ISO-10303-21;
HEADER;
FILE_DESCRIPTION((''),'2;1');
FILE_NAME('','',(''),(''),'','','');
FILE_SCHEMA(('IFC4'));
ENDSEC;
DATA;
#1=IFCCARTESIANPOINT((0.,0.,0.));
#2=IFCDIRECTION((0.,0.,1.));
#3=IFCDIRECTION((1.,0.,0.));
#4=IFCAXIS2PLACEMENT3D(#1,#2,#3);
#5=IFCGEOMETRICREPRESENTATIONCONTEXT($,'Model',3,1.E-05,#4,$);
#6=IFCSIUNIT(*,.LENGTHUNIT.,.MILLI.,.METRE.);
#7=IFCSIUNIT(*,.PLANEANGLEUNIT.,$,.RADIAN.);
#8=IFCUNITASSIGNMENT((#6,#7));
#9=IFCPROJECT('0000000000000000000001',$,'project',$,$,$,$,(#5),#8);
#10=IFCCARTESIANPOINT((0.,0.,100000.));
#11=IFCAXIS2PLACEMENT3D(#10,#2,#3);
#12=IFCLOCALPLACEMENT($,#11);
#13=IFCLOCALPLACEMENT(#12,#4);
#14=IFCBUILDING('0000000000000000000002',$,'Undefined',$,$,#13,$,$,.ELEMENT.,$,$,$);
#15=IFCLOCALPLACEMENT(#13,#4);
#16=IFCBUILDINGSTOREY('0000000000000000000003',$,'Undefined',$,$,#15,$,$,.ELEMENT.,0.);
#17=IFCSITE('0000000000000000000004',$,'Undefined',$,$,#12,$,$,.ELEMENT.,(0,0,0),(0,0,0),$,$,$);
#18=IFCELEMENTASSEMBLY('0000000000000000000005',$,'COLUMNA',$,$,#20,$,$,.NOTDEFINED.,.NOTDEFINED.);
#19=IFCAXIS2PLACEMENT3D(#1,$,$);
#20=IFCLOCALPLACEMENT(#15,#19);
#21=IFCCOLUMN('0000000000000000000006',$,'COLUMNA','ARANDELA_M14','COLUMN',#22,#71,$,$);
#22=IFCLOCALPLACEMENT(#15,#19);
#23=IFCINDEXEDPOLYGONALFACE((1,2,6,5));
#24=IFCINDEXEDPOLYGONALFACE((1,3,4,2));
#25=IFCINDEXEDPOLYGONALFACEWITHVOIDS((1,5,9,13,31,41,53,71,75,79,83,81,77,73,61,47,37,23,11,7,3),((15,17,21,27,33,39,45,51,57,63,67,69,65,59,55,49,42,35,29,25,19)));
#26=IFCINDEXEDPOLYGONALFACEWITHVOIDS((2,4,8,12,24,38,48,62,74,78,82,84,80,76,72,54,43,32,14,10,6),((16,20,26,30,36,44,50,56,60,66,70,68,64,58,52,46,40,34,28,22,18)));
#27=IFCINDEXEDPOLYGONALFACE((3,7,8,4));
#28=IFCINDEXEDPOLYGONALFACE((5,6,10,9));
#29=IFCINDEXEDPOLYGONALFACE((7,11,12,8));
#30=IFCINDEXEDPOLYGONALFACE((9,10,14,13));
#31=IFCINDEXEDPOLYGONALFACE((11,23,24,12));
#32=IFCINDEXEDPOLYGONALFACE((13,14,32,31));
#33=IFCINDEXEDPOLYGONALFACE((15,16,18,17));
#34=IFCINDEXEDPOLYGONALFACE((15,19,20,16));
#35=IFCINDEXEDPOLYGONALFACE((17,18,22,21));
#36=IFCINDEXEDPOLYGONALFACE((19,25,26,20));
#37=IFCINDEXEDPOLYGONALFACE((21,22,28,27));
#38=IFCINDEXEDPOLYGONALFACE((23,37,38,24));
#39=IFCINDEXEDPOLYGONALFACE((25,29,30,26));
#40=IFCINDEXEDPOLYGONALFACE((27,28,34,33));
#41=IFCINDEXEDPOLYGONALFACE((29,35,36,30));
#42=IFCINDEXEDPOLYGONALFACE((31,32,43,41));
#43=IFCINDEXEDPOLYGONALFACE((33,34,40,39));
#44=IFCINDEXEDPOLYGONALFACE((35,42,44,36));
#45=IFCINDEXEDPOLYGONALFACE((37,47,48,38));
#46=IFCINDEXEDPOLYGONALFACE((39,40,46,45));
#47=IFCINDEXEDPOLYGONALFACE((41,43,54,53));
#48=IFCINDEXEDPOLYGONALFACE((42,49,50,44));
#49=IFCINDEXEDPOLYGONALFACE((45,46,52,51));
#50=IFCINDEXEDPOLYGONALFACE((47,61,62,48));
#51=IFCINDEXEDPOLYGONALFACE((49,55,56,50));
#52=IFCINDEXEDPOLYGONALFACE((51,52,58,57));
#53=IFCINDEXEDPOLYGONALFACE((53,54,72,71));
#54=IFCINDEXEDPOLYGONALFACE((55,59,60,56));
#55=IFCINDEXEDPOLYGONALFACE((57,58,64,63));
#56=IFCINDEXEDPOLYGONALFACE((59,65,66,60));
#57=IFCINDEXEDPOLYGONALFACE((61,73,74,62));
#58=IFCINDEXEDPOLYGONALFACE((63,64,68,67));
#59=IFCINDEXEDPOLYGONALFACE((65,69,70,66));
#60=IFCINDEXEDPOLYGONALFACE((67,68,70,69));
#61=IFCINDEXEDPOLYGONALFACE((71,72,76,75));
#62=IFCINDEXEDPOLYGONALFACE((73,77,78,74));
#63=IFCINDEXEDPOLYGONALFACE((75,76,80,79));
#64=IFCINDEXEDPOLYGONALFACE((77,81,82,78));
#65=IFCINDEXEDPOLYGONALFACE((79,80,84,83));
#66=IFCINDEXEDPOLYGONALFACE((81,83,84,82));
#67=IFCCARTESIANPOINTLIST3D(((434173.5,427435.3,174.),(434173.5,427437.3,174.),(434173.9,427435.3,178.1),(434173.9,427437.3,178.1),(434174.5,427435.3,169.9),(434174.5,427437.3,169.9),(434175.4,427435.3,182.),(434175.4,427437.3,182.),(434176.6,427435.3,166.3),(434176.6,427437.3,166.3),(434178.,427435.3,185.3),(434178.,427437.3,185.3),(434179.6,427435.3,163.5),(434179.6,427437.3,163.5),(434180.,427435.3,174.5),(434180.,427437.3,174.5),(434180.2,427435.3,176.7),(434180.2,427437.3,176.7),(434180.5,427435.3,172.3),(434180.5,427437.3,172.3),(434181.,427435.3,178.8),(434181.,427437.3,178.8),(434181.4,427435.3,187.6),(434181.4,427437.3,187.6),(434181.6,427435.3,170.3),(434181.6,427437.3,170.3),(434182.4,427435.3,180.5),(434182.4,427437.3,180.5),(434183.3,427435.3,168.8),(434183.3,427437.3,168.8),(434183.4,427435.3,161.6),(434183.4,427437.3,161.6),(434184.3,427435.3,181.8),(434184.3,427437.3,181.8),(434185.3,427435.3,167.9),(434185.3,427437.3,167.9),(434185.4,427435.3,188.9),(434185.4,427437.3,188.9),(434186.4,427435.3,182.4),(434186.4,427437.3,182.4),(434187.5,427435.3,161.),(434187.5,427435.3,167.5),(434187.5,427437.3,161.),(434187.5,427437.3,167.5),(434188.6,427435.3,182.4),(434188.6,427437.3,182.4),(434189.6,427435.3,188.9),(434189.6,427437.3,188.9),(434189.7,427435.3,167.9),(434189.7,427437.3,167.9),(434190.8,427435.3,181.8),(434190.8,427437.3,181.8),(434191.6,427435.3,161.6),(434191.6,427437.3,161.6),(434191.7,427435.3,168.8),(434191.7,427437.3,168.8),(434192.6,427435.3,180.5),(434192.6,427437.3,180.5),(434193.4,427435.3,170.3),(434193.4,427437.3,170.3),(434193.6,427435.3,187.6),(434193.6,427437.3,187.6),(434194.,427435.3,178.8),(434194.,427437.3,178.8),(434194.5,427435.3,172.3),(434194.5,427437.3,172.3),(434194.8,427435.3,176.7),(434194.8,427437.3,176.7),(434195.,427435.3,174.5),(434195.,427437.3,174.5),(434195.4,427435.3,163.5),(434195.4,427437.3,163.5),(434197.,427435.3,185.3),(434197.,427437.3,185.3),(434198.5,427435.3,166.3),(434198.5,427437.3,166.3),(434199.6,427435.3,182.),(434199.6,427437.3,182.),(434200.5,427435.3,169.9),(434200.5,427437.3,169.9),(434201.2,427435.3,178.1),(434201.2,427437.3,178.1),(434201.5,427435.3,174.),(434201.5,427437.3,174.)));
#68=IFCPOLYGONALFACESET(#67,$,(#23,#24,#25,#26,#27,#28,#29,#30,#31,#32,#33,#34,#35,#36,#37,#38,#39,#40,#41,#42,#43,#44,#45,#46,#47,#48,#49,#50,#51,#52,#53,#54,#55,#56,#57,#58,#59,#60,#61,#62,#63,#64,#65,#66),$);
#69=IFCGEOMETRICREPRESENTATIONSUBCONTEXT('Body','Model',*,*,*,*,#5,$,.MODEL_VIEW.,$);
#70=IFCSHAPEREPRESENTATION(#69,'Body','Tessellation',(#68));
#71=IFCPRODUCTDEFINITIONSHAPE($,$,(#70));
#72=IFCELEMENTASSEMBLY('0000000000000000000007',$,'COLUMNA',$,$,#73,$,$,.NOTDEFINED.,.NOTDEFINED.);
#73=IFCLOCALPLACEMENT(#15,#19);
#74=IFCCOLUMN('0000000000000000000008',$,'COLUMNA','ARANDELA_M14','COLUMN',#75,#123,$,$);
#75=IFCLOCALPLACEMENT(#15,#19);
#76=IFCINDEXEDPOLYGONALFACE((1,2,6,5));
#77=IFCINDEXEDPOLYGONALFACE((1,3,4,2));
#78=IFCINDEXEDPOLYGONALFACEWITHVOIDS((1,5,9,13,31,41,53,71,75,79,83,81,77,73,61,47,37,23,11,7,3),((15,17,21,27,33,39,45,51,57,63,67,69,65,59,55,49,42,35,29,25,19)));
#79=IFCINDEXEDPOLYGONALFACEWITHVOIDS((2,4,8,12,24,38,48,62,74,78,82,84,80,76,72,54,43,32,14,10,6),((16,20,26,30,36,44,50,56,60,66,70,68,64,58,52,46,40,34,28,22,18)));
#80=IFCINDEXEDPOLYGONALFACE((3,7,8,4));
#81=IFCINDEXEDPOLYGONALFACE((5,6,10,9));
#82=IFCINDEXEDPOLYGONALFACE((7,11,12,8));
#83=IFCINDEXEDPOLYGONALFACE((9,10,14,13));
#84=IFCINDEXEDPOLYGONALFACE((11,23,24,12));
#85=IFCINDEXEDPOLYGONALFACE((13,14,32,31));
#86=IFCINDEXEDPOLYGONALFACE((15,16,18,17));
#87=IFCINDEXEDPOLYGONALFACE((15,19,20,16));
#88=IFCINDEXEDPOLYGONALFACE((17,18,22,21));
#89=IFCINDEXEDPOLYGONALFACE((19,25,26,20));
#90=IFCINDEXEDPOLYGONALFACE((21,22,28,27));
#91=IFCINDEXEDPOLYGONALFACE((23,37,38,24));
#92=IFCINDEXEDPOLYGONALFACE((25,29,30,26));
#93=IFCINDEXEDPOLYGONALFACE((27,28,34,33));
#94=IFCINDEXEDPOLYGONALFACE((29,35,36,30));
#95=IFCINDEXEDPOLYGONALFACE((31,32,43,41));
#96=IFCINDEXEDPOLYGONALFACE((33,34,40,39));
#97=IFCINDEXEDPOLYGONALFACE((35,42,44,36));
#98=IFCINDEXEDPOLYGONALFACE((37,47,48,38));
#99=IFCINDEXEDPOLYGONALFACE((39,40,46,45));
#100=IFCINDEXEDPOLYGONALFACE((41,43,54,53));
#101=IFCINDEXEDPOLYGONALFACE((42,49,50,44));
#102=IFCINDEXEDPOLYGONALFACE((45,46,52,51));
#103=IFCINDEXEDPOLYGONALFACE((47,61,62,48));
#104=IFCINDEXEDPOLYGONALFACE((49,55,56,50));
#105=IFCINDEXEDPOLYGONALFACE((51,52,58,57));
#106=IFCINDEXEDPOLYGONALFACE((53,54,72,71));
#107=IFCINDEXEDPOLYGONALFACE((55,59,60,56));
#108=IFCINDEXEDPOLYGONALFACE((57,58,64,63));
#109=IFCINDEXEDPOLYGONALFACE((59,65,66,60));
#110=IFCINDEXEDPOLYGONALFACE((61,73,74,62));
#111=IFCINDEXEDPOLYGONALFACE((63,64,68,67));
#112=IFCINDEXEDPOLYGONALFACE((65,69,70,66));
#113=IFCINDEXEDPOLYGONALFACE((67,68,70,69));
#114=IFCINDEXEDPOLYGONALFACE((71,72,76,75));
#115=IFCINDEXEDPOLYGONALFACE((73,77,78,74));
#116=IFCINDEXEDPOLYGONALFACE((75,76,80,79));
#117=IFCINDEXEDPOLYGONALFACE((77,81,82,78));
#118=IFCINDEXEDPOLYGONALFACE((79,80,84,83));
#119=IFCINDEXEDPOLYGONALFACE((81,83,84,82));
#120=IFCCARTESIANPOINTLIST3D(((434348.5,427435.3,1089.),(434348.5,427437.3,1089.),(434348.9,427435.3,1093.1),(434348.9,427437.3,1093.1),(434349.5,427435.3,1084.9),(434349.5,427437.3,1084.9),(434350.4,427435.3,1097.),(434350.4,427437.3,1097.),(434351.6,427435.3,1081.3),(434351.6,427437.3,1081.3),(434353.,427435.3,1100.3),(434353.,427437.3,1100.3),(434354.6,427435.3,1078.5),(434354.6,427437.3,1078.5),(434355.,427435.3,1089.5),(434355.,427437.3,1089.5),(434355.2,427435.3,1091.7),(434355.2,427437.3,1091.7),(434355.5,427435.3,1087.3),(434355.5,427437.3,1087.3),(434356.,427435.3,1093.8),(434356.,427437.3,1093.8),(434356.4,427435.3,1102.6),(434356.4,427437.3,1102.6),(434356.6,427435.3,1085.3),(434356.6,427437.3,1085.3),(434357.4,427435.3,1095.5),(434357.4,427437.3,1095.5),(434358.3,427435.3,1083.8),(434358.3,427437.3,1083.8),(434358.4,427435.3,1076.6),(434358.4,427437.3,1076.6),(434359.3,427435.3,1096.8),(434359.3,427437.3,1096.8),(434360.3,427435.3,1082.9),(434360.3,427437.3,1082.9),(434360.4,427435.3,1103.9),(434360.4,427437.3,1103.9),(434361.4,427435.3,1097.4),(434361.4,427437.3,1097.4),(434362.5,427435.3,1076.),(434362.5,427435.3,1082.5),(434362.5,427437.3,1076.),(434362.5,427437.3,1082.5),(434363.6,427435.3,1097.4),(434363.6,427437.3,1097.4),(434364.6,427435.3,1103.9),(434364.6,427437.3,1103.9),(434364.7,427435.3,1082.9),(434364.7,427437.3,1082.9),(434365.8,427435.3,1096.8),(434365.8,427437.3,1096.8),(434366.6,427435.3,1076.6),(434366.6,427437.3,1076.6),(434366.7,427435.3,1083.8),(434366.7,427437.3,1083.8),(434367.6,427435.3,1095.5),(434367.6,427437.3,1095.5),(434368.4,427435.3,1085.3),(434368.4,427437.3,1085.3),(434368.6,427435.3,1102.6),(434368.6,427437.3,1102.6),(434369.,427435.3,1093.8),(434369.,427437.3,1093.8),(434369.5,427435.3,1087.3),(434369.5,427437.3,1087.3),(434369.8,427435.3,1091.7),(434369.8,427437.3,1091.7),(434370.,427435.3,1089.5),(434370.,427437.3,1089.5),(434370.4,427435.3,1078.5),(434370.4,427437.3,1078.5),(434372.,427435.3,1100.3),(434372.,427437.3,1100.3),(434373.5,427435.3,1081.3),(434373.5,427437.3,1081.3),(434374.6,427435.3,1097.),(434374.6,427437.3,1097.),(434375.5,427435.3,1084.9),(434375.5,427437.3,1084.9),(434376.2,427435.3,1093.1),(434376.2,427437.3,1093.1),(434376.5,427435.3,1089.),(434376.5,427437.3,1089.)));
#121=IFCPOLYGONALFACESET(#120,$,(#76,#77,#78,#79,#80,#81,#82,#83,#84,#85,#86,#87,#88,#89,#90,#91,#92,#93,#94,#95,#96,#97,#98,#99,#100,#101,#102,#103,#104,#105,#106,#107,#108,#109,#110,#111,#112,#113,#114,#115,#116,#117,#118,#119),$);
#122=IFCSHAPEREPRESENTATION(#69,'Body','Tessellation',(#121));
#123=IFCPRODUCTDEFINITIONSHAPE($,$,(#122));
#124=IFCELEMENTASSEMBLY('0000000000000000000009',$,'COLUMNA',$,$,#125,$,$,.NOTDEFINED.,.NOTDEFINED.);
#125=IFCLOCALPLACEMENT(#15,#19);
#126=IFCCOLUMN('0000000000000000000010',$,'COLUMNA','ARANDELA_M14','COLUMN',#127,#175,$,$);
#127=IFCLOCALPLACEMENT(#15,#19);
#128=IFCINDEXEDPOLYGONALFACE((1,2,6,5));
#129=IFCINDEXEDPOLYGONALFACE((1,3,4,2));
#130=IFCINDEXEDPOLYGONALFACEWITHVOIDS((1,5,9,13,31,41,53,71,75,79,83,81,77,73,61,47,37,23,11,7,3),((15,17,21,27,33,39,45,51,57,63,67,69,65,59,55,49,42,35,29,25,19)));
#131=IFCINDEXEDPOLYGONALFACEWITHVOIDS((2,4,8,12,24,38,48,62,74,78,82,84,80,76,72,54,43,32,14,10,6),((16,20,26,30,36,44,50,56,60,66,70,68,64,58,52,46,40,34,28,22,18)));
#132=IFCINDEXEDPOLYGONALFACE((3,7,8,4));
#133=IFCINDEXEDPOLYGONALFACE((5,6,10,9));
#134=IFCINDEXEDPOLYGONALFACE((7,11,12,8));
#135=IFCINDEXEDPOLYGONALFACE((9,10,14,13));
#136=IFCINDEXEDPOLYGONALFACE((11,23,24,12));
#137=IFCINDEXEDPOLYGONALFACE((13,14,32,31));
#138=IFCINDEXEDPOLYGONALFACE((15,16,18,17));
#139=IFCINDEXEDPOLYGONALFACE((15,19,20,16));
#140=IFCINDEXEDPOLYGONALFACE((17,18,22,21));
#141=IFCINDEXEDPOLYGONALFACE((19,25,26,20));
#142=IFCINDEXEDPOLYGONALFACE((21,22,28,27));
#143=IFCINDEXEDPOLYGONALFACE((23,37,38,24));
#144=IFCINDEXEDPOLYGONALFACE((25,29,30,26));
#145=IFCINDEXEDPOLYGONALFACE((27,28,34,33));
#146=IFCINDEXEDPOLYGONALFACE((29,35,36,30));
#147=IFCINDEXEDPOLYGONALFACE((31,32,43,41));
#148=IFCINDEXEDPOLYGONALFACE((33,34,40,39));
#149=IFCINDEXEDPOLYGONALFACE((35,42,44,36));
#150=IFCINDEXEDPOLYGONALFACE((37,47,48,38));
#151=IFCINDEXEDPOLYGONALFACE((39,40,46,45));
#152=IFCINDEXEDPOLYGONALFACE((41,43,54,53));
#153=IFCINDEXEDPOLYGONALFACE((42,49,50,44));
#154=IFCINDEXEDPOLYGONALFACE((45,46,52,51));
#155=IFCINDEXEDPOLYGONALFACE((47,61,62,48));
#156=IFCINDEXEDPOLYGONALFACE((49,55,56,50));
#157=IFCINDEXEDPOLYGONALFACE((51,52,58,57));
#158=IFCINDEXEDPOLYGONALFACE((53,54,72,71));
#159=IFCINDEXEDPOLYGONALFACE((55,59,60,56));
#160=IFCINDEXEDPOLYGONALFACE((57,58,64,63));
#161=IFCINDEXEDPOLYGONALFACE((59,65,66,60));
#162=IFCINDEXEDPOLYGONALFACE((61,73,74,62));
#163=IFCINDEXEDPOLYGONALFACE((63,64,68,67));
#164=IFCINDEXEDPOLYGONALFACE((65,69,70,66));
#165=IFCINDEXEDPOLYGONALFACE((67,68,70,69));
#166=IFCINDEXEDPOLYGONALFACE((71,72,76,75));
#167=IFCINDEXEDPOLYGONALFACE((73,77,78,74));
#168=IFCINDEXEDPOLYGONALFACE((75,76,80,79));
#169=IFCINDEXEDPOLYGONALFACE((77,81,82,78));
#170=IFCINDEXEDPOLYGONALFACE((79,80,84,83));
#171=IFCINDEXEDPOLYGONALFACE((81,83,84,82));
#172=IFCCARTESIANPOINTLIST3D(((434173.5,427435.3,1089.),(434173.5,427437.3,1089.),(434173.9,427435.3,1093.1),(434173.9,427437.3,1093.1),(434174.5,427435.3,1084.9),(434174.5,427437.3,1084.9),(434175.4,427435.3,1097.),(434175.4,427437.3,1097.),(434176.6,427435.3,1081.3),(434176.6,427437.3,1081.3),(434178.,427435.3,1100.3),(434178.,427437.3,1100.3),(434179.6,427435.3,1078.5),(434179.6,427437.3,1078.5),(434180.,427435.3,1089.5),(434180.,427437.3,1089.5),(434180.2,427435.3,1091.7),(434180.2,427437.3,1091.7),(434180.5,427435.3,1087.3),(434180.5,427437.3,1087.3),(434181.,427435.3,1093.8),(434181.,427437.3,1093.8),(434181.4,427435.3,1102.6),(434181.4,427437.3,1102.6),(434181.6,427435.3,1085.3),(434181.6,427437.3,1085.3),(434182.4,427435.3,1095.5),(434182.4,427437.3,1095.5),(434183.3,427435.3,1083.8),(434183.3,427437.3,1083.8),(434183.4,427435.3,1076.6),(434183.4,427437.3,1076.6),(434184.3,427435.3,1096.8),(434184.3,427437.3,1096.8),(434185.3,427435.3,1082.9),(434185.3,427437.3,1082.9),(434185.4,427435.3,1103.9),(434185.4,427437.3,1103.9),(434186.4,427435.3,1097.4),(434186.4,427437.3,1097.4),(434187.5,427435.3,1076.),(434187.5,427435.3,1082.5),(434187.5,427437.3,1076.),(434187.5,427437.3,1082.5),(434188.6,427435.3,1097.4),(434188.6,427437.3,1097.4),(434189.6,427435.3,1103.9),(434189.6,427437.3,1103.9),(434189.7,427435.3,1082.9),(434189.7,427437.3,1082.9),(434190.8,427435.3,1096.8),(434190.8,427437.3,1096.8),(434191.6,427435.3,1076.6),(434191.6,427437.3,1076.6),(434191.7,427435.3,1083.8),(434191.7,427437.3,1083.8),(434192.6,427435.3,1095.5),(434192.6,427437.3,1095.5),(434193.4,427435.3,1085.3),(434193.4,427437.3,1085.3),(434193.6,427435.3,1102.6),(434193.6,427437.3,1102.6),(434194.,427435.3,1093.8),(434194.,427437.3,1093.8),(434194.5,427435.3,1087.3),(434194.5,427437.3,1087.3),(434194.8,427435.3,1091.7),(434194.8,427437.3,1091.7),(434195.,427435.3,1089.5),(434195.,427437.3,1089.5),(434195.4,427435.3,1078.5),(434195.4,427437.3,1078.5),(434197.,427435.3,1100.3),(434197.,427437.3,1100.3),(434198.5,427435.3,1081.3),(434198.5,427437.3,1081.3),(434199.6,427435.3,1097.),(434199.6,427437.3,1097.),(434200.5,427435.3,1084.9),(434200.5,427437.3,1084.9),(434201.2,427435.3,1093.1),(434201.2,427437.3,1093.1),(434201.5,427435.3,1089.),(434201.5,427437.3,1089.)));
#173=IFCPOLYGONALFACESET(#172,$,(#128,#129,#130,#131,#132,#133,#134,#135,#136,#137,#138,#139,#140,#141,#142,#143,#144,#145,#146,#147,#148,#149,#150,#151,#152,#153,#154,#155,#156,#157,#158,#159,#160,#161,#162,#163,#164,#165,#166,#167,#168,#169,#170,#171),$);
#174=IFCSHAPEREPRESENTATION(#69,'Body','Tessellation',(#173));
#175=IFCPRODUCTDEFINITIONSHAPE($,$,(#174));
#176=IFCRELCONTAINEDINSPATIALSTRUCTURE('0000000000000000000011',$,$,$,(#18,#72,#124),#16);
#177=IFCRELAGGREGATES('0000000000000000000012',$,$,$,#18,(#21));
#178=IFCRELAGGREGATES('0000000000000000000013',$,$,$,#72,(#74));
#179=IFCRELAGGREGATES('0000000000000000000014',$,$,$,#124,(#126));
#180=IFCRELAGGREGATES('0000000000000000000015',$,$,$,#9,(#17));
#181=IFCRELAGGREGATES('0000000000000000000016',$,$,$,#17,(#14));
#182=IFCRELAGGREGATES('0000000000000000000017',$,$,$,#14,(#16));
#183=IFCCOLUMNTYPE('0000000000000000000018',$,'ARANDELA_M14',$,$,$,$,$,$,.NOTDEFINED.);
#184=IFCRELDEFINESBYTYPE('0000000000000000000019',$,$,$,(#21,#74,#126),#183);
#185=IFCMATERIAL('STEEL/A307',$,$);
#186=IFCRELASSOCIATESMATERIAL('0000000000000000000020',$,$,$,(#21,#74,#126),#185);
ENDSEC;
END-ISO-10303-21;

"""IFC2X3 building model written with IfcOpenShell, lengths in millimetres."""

from ifc_helpers import new_model, si_unit, frame, origin_with_axes, origin_2d_with_axis, place, context, subcontext, project, spatial, hollow_circle, extrude, material, type_object, element, aggregate, save


model = new_model("IFC2X3")

# Units and contexts
model_context = context("Model", 3, precision=1e-05, world=origin_with_axes())
body_context = subcontext(model_context, "Body", "Model", "MODEL_VIEW")
ifc_project = project(units=[si_unit("LENGTHUNIT", "METRE", prefix="MILLI"), si_unit("PLANEANGLEUNIT", "RADIAN")], contexts=[model_context])

# Site, building, storey
site_placement = place(None, frame((0.0, 0.0, 100000.0), z_axis=(0.0, 0.0, 1.0), x_axis=(1.0, 0.0, 0.0)))
site = spatial("IfcSite", under=ifc_project, at=site_placement, Name="Undefined", CompositionType="ELEMENT", RefLatitude=(0, 0, 0), RefLongitude=(0, 0, 0))
building_placement = place(site_placement, origin_with_axes())
building = spatial("IfcBuilding", under=site, at=building_placement, Name="Undefined", CompositionType="ELEMENT")
storey_placement = place(building_placement, origin_with_axes())
storey = spatial("IfcBuildingStorey", under=building, at=storey_placement, Name="Undefined", CompositionType="ELEMENT", Elevation=0.0)

# Element assemblies, columns
ifc_material_1 = material(Name="STEEL/A307")
column_type_1 = type_object("IfcColumnType", Name="ARANDELA_M14", PredefinedType="NOTDEFINED")
assembly_1_placement = place(storey_placement, origin_with_axes())
assembly_1 = element("IfcElementAssembly", 1, at=assembly_1_placement, inside=storey, Name="COLUMNA", AssemblyPlace="NOTDEFINED", PredefinedType="NOTDEFINED")
column_1_placement = place(assembly_1_placement, frame((434187.5, 427437.3, 175.0), z_axis=(0.0, -1.0, 0.000285), x_axis=(-1.0, 0.0, 0.0)))
column_1 = element("IfcColumn", 2, at=column_1_placement, type_object=column_type_1, material=ifc_material_1, Name="COLUMNA", Description="ARANDELA_M14", ObjectType="COLUMN", context=body_context, shape_type="SweptSolid", body=[
    extrude(hollow_circle(Radius=14.0, WallThickness=6.5, at=origin_2d_with_axis()), frame((0.0, 0.0, 2.0), z_axis=(0.0, 0.0, -1.0), x_axis=(0.0, 1.0, 0.0)), (0.0, 0.0, 1.0), 2.0),
])
aggregate(assembly_1, [column_1])
assembly_2_placement = place(storey_placement, origin_with_axes())
assembly_2 = element("IfcElementAssembly", 3, at=assembly_2_placement, inside=storey, Name="COLUMNA", AssemblyPlace="NOTDEFINED", PredefinedType="NOTDEFINED")
column_2_placement = place(assembly_2_placement, frame((434362.5, 427437.3, 1090.0), z_axis=(0.0, -1.0, 0.000285), x_axis=(-1.0, 0.0, 0.0)))
column_2 = element("IfcColumn", 4, at=column_2_placement, type_object=column_type_1, material=ifc_material_1, Name="COLUMNA", Description="ARANDELA_M14", ObjectType="COLUMN", context=body_context, shape_type="SweptSolid", body=[
    extrude(hollow_circle(Radius=14.0, WallThickness=6.5, at=origin_2d_with_axis()), frame((0.0, 0.0, 2.0), z_axis=(0.0, 0.0, -1.0), x_axis=(0.0, 1.0, 0.0)), (0.0, 0.0, 1.0), 2.0),
])
aggregate(assembly_2, [column_2])
assembly_3_placement = place(storey_placement, origin_with_axes())
assembly_3 = element("IfcElementAssembly", 5, at=assembly_3_placement, inside=storey, Name="COLUMNA", AssemblyPlace="NOTDEFINED", PredefinedType="NOTDEFINED")
column_3_placement = place(assembly_3_placement, frame((434187.5, 427437.3, 1090.0), z_axis=(0.0, -1.0, 0.000285), x_axis=(-1.0, 0.0, 0.0)))
column_3 = element("IfcColumn", 6, at=column_3_placement, type_object=column_type_1, material=ifc_material_1, Name="COLUMNA", Description="ARANDELA_M14", ObjectType="COLUMN", context=body_context, shape_type="SweptSolid", body=[
    extrude(hollow_circle(Radius=14.0, WallThickness=6.5, at=origin_2d_with_axis()), frame((0.0, 0.0, 2.0), z_axis=(0.0, 0.0, -1.0), x_axis=(0.0, 1.0, 0.0)), (0.0, 0.0, 1.0), 2.0),
])
aggregate(assembly_3, [column_3])

save(model, "model.ifc")
